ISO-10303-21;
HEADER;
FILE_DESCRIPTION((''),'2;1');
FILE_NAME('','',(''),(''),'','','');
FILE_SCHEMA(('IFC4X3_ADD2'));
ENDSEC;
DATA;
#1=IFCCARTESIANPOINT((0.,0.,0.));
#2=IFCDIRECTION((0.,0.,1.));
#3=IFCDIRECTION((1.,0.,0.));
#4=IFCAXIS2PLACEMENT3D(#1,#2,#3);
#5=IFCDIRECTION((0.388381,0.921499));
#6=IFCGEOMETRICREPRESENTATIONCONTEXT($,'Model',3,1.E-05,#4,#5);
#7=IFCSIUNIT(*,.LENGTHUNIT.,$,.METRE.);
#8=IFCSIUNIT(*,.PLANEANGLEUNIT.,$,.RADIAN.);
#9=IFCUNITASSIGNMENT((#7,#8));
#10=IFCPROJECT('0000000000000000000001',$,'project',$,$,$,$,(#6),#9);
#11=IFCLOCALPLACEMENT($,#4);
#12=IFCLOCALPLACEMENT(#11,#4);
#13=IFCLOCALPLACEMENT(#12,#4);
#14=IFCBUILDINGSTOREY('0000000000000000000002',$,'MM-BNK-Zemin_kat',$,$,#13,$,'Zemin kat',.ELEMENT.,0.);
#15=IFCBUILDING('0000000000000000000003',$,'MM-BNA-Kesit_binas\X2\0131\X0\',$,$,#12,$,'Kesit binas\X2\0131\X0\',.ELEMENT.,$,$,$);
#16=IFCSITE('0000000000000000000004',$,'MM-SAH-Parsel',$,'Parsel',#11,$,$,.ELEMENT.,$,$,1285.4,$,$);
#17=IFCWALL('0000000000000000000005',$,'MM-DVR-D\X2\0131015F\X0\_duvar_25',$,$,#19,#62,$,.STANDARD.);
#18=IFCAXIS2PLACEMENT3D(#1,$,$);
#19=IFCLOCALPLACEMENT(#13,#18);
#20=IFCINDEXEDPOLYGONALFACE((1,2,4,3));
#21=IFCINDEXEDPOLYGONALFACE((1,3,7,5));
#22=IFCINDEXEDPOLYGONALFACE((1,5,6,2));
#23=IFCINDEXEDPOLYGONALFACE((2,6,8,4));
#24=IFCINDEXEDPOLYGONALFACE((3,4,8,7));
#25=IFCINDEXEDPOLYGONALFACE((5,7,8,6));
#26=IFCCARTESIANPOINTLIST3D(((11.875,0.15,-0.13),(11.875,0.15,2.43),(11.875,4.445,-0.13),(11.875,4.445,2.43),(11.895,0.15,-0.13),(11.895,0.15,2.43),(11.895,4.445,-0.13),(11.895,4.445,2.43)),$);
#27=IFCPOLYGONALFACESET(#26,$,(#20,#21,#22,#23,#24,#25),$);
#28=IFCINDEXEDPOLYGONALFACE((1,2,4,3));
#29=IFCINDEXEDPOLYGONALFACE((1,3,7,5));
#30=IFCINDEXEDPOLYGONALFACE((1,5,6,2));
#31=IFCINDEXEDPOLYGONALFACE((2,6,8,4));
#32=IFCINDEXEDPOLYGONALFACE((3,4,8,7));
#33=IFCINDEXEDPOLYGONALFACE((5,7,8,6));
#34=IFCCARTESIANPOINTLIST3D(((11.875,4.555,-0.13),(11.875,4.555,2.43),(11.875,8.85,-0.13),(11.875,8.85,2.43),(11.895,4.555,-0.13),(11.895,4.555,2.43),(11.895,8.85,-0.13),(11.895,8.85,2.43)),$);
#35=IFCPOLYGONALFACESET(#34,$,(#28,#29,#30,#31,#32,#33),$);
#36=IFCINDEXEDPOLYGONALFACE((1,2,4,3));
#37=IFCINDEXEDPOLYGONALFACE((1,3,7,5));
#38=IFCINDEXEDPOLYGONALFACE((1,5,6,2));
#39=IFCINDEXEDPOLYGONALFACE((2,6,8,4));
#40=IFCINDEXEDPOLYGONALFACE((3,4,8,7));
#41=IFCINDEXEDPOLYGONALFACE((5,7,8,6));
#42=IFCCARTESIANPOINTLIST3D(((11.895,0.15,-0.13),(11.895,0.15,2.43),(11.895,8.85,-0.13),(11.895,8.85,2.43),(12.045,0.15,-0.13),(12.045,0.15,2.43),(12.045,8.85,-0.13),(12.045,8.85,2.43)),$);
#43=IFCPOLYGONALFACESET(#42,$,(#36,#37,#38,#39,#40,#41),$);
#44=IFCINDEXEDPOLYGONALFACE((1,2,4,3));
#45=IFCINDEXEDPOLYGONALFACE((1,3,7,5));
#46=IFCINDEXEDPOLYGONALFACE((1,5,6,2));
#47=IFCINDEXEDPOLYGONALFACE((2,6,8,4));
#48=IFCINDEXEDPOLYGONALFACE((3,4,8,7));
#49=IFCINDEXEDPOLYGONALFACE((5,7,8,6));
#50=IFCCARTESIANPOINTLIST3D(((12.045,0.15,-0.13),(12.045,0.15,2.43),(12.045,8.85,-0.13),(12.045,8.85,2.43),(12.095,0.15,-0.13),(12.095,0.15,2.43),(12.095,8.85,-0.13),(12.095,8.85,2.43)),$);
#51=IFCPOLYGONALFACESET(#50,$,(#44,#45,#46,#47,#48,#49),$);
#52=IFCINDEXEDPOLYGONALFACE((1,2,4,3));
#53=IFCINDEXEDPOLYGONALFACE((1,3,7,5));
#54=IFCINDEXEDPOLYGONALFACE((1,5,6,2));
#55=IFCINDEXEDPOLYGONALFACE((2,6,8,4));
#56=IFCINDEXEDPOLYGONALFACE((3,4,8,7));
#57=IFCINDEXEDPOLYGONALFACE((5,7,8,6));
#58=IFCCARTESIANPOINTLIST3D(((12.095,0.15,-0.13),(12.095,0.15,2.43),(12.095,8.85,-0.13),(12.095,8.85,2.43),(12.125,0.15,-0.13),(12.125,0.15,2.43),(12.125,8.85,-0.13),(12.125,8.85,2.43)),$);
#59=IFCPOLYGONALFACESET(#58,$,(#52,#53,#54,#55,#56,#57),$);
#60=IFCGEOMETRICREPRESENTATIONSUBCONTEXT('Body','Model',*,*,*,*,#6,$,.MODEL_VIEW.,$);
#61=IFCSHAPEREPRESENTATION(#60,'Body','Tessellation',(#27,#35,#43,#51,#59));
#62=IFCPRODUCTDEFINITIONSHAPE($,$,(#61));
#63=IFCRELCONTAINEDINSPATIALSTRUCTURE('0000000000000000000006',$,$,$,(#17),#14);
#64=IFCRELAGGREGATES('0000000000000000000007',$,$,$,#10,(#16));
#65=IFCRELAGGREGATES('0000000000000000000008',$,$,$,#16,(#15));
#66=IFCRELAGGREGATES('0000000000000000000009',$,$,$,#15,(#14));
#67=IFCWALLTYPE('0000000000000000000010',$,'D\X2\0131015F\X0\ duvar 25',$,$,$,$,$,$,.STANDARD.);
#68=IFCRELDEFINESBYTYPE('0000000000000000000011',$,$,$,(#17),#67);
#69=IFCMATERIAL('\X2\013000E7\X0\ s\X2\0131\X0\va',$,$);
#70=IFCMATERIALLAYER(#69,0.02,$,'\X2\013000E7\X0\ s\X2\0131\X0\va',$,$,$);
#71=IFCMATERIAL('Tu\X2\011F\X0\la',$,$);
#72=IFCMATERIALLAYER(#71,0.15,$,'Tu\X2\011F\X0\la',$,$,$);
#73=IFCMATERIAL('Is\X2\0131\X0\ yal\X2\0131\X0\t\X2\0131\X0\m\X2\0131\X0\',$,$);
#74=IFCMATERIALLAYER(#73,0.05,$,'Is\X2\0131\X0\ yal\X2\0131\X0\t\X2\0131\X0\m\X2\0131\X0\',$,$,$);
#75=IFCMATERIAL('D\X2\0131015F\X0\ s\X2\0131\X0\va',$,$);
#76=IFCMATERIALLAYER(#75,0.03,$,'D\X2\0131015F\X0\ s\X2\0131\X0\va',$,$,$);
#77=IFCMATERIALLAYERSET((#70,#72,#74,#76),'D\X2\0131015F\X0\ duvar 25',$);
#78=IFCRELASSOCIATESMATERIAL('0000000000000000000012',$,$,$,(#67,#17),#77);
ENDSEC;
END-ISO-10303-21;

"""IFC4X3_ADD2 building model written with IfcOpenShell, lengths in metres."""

from ifc_helpers import new_model, si_unit, direction, frame, origin_with_axes, place, context, subcontext, project, spatial, polyline, outline, extrude, material, layer, layer_set, type_object, element, save


model = new_model("IFC4X3_ADD2")

# Units and contexts
model_context = context("Model", 3, precision=1e-05, world=origin_with_axes(), true_north=direction((0.388381, 0.921499)))
body_context = subcontext(model_context, "Body", "Model", "MODEL_VIEW")
ifc_project = project(units=[si_unit("LENGTHUNIT", "METRE"), si_unit("PLANEANGLEUNIT", "RADIAN")], contexts=[model_context])

# Site, building, storey
site_placement = place(None, origin_with_axes())
site = spatial("IfcSite", under=ifc_project, at=site_placement, Name="MM-SAH-Parsel", ObjectType="Parsel", CompositionType="ELEMENT", RefElevation=1285.4)
building_placement = place(site_placement, origin_with_axes())
building = spatial("IfcBuilding", under=site, at=building_placement, Name="MM-BNA-Kesit_binası", LongName="Kesit binası", CompositionType="ELEMENT")
storey_placement = place(building_placement, origin_with_axes())
storey = spatial("IfcBuildingStorey", under=building, at=storey_placement, Name="MM-BNK-Zemin_kat", LongName="Zemin kat", CompositionType="ELEMENT", Elevation=0.0)

# Shared definitions
ifc_material_1 = material(Name="İç sıva")
ifc_layer_1 = layer(ifc_material_1, 0.02, Name="İç sıva")
ifc_material_2 = material(Name="Tuğla")
ifc_layer_2 = layer(ifc_material_2, 0.15, Name="Tuğla")
ifc_material_3 = material(Name="Isı yalıtımı")
ifc_layer_3 = layer(ifc_material_3, 0.05, Name="Isı yalıtımı")
ifc_material_4 = material(Name="Dış sıva")
ifc_layer_4 = layer(ifc_material_4, 0.03, Name="Dış sıva")
ifc_layer_set_1 = layer_set([ifc_layer_1, ifc_layer_2, ifc_layer_3, ifc_layer_4], Name="Dış duvar 25")
wall_type_1 = type_object("IfcWallType", Name="Dış duvar 25", PredefinedType="STANDARD", material=ifc_layer_set_1)

# Wall
wall_1_placement = place(storey_placement, origin_with_axes())
element("IfcWall", 1, at=wall_1_placement, inside=storey, type_object=wall_type_1, material=ifc_layer_set_1, Name="MM-DVR-Dış_duvar_25", PredefinedType="STANDARD", context=body_context, shape_type="SweptSolid", body=[
    extrude(outline(polyline([(11.895, 0.15), (11.895, 4.445), (11.875, 4.445), (11.875, 0.15), (11.895, 0.15)])), frame((0.0, 0.0, -0.13)), (0.0, 0.0, 1.0), 2.56),
    extrude(outline(polyline([(11.895, 4.555), (11.895, 8.85), (11.875, 8.85), (11.875, 4.555), (11.895, 4.555)])), frame((0.0, 0.0, -0.13)), (0.0, 0.0, 1.0), 2.56),
    extrude(outline(polyline([(12.045, 0.15), (12.045, 8.85), (11.895, 8.85), (11.895, 0.15), (12.045, 0.15)])), frame((0.0, 0.0, -0.13)), (0.0, 0.0, 1.0), 2.56),
    extrude(outline(polyline([(12.095, 0.15), (12.095, 8.85), (12.045, 8.85), (12.045, 0.15), (12.095, 0.15)])), frame((0.0, 0.0, -0.13)), (0.0, 0.0, 1.0), 2.56),
    extrude(outline(polyline([(12.125, 0.15), (12.125, 8.85), (12.095, 8.85), (12.095, 0.15), (12.125, 0.15)])), frame((0.0, 0.0, -0.13)), (0.0, 0.0, 1.0), 2.56),
])

save(model, "model.ifc")
